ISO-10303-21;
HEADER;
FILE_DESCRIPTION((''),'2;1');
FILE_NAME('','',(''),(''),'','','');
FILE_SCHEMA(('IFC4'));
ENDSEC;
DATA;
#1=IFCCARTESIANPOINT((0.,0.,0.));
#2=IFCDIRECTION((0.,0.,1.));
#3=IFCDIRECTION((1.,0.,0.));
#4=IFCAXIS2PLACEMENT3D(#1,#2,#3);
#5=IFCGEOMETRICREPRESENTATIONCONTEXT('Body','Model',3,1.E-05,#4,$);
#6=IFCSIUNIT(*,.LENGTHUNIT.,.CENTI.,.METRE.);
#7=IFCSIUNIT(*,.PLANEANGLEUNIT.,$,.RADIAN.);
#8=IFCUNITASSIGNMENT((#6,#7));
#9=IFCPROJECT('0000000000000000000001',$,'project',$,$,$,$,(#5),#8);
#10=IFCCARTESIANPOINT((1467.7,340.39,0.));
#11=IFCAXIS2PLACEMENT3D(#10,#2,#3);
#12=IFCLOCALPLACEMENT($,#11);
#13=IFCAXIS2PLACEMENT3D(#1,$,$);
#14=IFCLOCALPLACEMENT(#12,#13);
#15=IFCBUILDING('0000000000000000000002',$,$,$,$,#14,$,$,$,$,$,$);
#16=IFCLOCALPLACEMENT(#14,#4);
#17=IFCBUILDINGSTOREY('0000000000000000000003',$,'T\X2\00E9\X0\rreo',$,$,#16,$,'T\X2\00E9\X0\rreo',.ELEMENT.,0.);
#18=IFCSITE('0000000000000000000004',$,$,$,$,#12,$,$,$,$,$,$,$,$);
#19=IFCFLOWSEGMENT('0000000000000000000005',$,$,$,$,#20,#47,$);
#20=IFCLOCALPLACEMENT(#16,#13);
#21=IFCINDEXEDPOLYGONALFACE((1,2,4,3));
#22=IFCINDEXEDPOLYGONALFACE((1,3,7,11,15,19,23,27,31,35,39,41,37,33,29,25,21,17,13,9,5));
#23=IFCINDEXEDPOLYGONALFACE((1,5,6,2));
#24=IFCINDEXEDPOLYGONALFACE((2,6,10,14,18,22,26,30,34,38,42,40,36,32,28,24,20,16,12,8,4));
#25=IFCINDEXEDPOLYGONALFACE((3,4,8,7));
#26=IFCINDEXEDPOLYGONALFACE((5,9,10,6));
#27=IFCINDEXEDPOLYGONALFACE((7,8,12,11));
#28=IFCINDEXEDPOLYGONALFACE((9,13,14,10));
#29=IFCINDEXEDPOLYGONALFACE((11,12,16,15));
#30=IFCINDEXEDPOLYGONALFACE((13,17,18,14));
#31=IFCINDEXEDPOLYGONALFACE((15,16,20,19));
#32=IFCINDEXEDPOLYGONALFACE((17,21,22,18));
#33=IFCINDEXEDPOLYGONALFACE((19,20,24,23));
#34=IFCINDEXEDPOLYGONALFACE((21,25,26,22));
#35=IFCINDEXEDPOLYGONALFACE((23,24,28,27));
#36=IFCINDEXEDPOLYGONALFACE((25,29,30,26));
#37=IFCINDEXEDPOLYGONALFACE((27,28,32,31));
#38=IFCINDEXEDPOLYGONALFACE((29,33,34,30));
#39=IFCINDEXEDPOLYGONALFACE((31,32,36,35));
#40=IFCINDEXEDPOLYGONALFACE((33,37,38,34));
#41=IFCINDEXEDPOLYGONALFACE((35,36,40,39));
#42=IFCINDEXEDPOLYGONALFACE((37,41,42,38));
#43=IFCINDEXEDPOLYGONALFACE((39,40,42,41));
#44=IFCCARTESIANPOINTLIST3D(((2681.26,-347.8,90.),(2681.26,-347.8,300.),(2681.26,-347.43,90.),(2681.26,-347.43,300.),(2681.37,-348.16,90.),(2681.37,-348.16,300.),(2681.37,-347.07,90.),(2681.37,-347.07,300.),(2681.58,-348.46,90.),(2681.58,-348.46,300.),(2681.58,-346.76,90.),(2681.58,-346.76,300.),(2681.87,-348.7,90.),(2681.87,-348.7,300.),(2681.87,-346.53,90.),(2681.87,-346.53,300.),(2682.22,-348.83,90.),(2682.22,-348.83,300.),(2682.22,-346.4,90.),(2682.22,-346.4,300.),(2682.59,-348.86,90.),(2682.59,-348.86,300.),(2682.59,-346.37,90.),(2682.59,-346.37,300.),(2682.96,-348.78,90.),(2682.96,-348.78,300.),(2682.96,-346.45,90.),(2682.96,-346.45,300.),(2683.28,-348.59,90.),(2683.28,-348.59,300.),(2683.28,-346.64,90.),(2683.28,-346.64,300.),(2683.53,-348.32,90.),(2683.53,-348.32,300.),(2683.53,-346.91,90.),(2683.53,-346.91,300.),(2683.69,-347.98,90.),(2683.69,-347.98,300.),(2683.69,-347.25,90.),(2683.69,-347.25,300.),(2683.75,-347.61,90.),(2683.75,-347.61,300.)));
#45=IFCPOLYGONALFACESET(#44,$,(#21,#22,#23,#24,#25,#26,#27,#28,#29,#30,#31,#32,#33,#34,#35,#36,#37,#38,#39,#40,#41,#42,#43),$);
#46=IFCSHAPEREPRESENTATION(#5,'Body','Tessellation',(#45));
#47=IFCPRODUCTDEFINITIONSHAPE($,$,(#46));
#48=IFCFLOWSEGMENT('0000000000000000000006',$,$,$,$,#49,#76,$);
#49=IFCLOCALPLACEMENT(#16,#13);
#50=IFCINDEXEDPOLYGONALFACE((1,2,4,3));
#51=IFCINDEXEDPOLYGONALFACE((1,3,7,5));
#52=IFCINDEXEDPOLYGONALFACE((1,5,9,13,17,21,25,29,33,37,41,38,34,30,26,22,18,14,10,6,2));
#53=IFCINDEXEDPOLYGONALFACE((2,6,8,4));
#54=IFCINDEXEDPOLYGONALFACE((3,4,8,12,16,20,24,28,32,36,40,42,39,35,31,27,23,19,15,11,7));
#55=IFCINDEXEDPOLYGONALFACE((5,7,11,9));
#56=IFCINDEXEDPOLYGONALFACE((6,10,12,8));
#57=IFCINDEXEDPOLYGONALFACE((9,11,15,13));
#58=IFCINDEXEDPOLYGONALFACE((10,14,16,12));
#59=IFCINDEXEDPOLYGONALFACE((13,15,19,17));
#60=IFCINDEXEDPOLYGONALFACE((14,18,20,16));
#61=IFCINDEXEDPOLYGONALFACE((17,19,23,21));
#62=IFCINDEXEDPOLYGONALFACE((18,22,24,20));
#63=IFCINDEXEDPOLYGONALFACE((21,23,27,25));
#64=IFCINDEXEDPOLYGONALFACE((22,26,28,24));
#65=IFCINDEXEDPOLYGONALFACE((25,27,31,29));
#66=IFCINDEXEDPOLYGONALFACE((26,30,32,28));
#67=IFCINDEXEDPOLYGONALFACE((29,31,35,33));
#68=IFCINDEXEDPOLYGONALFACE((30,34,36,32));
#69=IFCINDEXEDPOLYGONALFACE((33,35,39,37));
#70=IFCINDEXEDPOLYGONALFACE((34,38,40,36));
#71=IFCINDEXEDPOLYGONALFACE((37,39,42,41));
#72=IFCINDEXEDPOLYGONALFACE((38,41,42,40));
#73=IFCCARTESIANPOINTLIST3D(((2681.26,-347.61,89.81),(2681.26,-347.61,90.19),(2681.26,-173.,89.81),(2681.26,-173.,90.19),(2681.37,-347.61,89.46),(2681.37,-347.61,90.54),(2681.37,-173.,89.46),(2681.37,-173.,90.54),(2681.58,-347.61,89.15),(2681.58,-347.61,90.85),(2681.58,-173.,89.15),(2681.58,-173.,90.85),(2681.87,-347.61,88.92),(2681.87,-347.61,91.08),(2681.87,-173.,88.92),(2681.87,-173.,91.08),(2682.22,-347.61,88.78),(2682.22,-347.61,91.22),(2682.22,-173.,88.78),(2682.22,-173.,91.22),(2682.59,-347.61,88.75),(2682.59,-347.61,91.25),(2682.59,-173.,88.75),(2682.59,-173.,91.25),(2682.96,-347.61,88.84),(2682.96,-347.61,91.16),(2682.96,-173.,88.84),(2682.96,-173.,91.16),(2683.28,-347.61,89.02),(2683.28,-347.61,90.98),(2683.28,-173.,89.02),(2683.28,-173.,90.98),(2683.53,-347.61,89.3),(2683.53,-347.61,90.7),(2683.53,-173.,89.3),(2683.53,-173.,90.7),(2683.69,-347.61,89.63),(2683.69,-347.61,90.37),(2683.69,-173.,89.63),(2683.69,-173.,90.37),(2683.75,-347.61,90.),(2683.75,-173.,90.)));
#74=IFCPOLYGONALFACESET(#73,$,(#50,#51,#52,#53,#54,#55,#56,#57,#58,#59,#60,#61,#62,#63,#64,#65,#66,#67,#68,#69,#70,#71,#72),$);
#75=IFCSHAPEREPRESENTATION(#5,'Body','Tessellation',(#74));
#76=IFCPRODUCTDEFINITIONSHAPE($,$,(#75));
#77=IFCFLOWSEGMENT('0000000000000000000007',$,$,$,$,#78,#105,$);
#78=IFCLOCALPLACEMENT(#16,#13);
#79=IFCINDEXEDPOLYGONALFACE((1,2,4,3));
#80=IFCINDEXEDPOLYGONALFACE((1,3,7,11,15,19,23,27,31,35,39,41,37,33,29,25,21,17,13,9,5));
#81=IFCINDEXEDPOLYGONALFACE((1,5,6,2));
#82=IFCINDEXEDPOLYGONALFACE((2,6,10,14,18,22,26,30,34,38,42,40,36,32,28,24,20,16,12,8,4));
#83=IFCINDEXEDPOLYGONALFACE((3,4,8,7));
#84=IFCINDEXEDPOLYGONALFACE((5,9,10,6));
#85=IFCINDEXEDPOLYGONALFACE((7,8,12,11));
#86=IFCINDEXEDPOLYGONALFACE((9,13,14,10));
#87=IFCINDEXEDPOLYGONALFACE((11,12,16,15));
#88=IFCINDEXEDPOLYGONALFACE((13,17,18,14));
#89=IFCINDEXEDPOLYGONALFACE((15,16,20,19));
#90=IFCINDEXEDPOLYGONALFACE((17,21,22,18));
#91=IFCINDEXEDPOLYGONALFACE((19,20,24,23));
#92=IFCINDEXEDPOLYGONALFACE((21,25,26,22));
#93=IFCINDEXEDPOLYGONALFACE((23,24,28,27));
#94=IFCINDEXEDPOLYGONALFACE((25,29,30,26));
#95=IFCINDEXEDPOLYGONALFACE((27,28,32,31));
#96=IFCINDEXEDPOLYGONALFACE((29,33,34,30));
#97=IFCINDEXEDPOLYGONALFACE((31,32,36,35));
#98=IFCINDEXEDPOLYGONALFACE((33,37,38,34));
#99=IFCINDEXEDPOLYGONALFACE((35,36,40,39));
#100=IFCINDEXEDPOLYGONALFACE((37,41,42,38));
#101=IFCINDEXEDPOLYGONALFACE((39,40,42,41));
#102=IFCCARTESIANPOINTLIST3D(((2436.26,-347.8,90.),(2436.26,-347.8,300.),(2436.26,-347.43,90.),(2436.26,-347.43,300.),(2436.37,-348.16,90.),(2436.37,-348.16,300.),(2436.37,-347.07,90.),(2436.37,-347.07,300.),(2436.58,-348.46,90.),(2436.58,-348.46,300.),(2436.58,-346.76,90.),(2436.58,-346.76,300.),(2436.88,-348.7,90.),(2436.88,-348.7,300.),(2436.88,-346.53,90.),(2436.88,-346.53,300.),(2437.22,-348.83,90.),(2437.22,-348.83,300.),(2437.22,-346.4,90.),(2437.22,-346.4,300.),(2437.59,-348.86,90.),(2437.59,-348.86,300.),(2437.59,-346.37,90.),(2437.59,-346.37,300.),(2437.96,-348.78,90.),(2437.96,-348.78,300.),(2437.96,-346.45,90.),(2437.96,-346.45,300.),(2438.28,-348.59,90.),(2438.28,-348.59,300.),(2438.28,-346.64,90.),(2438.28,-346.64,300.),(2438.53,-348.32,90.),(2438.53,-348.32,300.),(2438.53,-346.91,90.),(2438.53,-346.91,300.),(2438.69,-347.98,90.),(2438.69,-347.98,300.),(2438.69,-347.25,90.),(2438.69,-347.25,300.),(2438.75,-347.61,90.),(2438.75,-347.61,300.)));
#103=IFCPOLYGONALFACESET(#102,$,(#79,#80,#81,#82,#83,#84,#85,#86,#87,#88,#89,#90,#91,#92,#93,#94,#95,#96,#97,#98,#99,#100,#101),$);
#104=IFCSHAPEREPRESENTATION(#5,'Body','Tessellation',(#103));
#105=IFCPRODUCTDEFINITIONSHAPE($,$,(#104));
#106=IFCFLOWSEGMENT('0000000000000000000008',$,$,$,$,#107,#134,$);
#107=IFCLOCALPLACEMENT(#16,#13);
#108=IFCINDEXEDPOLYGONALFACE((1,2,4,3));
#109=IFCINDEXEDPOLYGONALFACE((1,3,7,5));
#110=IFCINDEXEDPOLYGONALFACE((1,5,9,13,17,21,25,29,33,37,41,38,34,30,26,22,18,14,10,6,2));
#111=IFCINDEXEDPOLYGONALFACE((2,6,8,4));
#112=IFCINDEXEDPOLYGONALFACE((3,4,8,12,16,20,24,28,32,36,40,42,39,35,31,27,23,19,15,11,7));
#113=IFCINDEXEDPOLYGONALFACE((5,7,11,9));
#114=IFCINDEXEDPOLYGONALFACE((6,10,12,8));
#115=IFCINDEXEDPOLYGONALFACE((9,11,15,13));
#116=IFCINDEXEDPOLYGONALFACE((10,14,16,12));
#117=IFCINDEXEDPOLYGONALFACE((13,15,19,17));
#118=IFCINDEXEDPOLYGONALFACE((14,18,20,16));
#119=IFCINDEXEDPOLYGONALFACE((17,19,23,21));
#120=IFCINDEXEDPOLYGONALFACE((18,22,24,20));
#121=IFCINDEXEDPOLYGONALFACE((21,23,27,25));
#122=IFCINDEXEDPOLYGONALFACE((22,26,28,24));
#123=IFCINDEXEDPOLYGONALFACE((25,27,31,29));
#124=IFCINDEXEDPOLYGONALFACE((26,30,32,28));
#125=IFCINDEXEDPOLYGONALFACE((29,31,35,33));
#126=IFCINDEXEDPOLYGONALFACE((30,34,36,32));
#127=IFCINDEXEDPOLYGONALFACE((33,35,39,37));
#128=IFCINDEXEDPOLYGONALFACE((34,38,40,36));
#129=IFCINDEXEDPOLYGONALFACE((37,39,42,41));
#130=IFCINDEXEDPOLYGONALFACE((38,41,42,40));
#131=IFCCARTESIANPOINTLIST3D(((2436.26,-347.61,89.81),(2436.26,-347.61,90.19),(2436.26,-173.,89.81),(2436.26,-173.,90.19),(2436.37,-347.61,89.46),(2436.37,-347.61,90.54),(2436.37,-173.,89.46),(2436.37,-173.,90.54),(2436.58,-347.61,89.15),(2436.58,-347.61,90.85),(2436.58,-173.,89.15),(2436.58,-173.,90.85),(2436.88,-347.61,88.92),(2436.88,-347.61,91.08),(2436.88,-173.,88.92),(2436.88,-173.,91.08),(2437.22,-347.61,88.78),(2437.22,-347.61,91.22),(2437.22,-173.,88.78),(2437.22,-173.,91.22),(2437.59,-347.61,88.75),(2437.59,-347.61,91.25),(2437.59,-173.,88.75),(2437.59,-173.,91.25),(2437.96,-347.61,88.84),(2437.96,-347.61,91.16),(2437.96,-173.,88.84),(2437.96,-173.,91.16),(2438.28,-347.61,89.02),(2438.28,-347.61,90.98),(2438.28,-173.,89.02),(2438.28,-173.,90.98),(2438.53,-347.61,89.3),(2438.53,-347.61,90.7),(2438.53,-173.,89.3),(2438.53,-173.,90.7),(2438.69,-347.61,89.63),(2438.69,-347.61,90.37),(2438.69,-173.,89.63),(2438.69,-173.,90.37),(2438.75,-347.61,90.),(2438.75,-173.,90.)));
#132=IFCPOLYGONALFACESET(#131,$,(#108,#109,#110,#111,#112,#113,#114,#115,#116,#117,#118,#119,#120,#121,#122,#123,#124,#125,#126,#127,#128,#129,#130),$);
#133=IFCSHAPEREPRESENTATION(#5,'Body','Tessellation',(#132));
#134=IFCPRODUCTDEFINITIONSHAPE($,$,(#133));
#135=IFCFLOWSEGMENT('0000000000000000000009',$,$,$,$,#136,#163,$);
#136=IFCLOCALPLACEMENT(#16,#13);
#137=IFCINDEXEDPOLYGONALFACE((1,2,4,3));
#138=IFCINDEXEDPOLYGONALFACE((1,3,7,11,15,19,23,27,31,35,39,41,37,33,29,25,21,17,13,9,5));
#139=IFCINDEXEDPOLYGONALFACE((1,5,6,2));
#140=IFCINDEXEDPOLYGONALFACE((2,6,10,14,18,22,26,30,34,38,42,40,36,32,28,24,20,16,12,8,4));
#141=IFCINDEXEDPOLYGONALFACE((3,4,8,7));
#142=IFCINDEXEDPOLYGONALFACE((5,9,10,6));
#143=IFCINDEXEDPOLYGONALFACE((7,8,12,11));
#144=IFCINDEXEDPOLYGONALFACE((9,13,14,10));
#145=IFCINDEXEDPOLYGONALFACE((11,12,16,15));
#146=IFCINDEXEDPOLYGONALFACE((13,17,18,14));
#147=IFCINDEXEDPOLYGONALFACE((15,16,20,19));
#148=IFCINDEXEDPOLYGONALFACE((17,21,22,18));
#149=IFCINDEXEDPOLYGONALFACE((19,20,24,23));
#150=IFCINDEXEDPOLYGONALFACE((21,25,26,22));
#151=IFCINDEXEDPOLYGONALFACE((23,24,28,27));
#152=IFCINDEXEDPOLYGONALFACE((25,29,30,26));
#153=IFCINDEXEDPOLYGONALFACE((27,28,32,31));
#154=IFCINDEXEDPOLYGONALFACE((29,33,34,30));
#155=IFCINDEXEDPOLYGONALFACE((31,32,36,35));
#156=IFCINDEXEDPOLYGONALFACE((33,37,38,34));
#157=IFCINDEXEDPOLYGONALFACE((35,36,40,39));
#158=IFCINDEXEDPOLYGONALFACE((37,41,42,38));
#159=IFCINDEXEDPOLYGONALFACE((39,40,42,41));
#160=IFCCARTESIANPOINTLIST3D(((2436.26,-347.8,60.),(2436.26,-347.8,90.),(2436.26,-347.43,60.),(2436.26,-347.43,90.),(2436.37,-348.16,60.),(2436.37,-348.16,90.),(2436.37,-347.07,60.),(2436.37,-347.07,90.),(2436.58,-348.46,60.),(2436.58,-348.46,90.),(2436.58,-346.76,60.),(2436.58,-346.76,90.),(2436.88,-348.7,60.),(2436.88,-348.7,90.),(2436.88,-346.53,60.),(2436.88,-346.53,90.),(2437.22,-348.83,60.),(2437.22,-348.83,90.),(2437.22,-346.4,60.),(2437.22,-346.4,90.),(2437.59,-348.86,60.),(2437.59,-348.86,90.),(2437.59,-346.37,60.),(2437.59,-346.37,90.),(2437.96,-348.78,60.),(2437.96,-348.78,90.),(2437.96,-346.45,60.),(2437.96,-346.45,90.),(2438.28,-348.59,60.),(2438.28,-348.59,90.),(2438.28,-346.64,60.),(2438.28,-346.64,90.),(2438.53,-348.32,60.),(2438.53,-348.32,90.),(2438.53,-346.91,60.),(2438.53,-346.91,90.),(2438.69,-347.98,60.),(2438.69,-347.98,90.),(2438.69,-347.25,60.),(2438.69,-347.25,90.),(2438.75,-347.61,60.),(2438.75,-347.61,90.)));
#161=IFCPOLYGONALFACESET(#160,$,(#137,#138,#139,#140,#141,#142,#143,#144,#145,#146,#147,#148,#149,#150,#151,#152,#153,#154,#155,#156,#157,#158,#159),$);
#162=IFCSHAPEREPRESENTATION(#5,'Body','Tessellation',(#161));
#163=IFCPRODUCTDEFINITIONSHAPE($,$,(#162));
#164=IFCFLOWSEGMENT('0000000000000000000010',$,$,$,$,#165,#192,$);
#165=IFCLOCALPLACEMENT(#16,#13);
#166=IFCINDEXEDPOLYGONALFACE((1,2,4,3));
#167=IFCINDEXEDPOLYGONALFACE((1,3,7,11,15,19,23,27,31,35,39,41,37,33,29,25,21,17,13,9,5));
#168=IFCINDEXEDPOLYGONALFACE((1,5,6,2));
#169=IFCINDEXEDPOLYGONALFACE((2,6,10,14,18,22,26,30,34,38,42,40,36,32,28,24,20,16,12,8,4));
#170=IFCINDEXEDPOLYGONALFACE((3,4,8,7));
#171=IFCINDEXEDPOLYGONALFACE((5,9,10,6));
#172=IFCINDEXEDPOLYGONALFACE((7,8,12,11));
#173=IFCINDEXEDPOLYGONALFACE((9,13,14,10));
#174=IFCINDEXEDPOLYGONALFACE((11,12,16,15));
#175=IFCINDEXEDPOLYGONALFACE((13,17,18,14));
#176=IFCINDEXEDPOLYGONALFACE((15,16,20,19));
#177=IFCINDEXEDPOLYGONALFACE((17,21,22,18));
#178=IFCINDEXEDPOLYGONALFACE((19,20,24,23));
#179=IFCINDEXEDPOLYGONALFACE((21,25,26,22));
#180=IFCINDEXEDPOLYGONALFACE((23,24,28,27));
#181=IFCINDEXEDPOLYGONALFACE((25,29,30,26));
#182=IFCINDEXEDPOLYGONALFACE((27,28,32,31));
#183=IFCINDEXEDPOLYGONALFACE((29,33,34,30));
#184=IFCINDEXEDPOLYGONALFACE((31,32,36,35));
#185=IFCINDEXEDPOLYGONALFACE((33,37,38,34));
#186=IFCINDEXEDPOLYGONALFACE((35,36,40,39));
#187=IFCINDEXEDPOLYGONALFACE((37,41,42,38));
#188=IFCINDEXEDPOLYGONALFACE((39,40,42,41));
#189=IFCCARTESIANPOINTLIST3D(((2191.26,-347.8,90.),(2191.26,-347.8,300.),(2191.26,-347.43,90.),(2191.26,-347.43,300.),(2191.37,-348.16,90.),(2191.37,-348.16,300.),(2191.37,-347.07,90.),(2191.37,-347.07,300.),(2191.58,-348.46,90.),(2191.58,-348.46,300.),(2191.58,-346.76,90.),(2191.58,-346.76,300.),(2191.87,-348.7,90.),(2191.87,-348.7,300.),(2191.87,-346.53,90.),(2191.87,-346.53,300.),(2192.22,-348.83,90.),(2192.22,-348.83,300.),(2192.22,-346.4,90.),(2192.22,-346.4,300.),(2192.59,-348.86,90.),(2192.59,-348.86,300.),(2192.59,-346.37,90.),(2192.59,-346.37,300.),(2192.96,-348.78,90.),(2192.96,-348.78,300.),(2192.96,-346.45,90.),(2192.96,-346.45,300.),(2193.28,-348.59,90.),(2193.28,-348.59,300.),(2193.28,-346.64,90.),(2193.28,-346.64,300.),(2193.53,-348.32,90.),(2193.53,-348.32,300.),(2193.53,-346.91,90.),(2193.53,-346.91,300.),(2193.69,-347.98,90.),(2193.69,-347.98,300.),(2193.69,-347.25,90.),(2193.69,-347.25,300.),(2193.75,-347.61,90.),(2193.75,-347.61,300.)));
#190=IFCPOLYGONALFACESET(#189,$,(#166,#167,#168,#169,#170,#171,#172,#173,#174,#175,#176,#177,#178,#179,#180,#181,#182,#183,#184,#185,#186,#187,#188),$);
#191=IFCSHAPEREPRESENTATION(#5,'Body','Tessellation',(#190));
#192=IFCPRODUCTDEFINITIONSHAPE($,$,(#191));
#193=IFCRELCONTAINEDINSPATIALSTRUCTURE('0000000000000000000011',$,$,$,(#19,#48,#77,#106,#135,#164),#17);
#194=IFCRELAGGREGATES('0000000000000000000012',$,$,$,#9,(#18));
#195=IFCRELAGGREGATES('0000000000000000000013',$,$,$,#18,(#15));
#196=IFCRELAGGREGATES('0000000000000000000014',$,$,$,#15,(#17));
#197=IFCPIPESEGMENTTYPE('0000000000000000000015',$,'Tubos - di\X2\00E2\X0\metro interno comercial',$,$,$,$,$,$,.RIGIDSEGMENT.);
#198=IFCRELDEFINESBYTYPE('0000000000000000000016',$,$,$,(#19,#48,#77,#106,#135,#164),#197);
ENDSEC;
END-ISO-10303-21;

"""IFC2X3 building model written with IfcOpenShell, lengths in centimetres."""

from ifc_helpers import new_model, si_unit, frame, origin, origin_with_axes, origin_2d_with_axis, place, context, project, spatial, circle, extrude, type_object, element, save


model = new_model("IFC2X3")

# Units and contexts
model_context = context("Model", 3, precision=1e-05, world=origin_with_axes(), identifier="Body")
ifc_project = project(units=[si_unit("LENGTHUNIT", "METRE", prefix="CENTI"), si_unit("PLANEANGLEUNIT", "RADIAN")], contexts=[model_context])

# Site, building, storey
site_placement = place(None, frame((1467.7, 340.39, 0.0), z_axis=(0.0, 0.0, 1.0), x_axis=(1.0, 0.0, 0.0)))
site = spatial("IfcSite", under=ifc_project, at=site_placement)
building_placement = place(site_placement, origin())
building = spatial("IfcBuilding", under=site, at=building_placement)
storey_placement = place(building_placement, origin_with_axes())
storey = spatial("IfcBuildingStorey", under=building, at=storey_placement, Name="Térreo", LongName="Térreo", CompositionType="ELEMENT", Elevation=0.0)

# Flow segments
pipe_segment_type_1 = type_object("IfcPipeSegmentType", Name="Tubos - diâmetro interno comercial", PredefinedType="RIGIDSEGMENT")
flow_segment_1_placement = place(storey_placement, frame((2682.5, -347.61, 300.0), z_axis=(0.0, 0.0, 1.0), x_axis=(1.0, 0.0, 0.0)))
element("IfcFlowSegment", 1, at=flow_segment_1_placement, inside=storey, type_object=pipe_segment_type_1, context=model_context, shape_type="SolidModel", body=[
    extrude(circle(Radius=1.25, at=origin_2d_with_axis()), frame((0.0, 0.0, 0.0), z_axis=(0.0, 0.0, -1.0), x_axis=(1.0, 0.0, 0.0)), (0.0, 0.0, 1.0), 210.0),
])
flow_segment_2_placement = place(storey_placement, frame((2682.5, -260.31, 91.25), z_axis=(0.0, 0.0, 1.0), x_axis=(1.0, 0.0, 0.0)))
element("IfcFlowSegment", 2, at=flow_segment_2_placement, inside=storey, type_object=pipe_segment_type_1, context=model_context, shape_type="SolidModel", body=[
    extrude(circle(Radius=1.25, at=origin_2d_with_axis()), frame((0.0, -87.31, -1.25), z_axis=(0.0, 1.0, 0.0), x_axis=(1.0, 0.0, 0.0)), (0.0, 0.0, 1.0), 174.61),
])
flow_segment_3_placement = place(storey_placement, frame((2437.5, -347.61, 300.0), z_axis=(0.0, 0.0, 1.0), x_axis=(1.0, 0.0, 0.0)))
element("IfcFlowSegment", 3, at=flow_segment_3_placement, inside=storey, type_object=pipe_segment_type_1, context=model_context, shape_type="SolidModel", body=[
    extrude(circle(Radius=1.25, at=origin_2d_with_axis()), frame((0.0, 0.0, 0.0), z_axis=(0.0, 0.0, -1.0), x_axis=(1.0, 0.0, 0.0)), (0.0, 0.0, 1.0), 210.0),
])
flow_segment_4_placement = place(storey_placement, frame((2437.5, -260.31, 91.25), z_axis=(0.0, 0.0, 1.0), x_axis=(1.0, 0.0, 0.0)))
element("IfcFlowSegment", 4, at=flow_segment_4_placement, inside=storey, type_object=pipe_segment_type_1, context=model_context, shape_type="SolidModel", body=[
    extrude(circle(Radius=1.25, at=origin_2d_with_axis()), frame((0.0, -87.31, -1.25), z_axis=(0.0, 1.0, 0.0), x_axis=(1.0, 0.0, 0.0)), (0.0, 0.0, 1.0), 174.61),
])
flow_segment_5_placement = place(storey_placement, frame((2437.5, -347.61, 90.0), z_axis=(0.0, 0.0, 1.0), x_axis=(1.0, 0.0, 0.0)))
element("IfcFlowSegment", 5, at=flow_segment_5_placement, inside=storey, type_object=pipe_segment_type_1, context=model_context, shape_type="SolidModel", body=[
    extrude(circle(Radius=1.25, at=origin_2d_with_axis()), frame((0.0, 0.0, 0.0), z_axis=(0.0, 0.0, -1.0), x_axis=(1.0, 0.0, 0.0)), (0.0, 0.0, 1.0), 30.0),
])
flow_segment_6_placement = place(storey_placement, frame((2192.5, -347.61, 300.0), z_axis=(0.0, 0.0, 1.0), x_axis=(1.0, 0.0, 0.0)))
element("IfcFlowSegment", 6, at=flow_segment_6_placement, inside=storey, type_object=pipe_segment_type_1, context=model_context, shape_type="SolidModel", body=[
    extrude(circle(Radius=1.25, at=origin_2d_with_axis()), frame((0.0, 0.0, 0.0), z_axis=(0.0, 0.0, -1.0), x_axis=(1.0, 0.0, 0.0)), (0.0, 0.0, 1.0), 210.0),
])

save(model, "model.ifc")
